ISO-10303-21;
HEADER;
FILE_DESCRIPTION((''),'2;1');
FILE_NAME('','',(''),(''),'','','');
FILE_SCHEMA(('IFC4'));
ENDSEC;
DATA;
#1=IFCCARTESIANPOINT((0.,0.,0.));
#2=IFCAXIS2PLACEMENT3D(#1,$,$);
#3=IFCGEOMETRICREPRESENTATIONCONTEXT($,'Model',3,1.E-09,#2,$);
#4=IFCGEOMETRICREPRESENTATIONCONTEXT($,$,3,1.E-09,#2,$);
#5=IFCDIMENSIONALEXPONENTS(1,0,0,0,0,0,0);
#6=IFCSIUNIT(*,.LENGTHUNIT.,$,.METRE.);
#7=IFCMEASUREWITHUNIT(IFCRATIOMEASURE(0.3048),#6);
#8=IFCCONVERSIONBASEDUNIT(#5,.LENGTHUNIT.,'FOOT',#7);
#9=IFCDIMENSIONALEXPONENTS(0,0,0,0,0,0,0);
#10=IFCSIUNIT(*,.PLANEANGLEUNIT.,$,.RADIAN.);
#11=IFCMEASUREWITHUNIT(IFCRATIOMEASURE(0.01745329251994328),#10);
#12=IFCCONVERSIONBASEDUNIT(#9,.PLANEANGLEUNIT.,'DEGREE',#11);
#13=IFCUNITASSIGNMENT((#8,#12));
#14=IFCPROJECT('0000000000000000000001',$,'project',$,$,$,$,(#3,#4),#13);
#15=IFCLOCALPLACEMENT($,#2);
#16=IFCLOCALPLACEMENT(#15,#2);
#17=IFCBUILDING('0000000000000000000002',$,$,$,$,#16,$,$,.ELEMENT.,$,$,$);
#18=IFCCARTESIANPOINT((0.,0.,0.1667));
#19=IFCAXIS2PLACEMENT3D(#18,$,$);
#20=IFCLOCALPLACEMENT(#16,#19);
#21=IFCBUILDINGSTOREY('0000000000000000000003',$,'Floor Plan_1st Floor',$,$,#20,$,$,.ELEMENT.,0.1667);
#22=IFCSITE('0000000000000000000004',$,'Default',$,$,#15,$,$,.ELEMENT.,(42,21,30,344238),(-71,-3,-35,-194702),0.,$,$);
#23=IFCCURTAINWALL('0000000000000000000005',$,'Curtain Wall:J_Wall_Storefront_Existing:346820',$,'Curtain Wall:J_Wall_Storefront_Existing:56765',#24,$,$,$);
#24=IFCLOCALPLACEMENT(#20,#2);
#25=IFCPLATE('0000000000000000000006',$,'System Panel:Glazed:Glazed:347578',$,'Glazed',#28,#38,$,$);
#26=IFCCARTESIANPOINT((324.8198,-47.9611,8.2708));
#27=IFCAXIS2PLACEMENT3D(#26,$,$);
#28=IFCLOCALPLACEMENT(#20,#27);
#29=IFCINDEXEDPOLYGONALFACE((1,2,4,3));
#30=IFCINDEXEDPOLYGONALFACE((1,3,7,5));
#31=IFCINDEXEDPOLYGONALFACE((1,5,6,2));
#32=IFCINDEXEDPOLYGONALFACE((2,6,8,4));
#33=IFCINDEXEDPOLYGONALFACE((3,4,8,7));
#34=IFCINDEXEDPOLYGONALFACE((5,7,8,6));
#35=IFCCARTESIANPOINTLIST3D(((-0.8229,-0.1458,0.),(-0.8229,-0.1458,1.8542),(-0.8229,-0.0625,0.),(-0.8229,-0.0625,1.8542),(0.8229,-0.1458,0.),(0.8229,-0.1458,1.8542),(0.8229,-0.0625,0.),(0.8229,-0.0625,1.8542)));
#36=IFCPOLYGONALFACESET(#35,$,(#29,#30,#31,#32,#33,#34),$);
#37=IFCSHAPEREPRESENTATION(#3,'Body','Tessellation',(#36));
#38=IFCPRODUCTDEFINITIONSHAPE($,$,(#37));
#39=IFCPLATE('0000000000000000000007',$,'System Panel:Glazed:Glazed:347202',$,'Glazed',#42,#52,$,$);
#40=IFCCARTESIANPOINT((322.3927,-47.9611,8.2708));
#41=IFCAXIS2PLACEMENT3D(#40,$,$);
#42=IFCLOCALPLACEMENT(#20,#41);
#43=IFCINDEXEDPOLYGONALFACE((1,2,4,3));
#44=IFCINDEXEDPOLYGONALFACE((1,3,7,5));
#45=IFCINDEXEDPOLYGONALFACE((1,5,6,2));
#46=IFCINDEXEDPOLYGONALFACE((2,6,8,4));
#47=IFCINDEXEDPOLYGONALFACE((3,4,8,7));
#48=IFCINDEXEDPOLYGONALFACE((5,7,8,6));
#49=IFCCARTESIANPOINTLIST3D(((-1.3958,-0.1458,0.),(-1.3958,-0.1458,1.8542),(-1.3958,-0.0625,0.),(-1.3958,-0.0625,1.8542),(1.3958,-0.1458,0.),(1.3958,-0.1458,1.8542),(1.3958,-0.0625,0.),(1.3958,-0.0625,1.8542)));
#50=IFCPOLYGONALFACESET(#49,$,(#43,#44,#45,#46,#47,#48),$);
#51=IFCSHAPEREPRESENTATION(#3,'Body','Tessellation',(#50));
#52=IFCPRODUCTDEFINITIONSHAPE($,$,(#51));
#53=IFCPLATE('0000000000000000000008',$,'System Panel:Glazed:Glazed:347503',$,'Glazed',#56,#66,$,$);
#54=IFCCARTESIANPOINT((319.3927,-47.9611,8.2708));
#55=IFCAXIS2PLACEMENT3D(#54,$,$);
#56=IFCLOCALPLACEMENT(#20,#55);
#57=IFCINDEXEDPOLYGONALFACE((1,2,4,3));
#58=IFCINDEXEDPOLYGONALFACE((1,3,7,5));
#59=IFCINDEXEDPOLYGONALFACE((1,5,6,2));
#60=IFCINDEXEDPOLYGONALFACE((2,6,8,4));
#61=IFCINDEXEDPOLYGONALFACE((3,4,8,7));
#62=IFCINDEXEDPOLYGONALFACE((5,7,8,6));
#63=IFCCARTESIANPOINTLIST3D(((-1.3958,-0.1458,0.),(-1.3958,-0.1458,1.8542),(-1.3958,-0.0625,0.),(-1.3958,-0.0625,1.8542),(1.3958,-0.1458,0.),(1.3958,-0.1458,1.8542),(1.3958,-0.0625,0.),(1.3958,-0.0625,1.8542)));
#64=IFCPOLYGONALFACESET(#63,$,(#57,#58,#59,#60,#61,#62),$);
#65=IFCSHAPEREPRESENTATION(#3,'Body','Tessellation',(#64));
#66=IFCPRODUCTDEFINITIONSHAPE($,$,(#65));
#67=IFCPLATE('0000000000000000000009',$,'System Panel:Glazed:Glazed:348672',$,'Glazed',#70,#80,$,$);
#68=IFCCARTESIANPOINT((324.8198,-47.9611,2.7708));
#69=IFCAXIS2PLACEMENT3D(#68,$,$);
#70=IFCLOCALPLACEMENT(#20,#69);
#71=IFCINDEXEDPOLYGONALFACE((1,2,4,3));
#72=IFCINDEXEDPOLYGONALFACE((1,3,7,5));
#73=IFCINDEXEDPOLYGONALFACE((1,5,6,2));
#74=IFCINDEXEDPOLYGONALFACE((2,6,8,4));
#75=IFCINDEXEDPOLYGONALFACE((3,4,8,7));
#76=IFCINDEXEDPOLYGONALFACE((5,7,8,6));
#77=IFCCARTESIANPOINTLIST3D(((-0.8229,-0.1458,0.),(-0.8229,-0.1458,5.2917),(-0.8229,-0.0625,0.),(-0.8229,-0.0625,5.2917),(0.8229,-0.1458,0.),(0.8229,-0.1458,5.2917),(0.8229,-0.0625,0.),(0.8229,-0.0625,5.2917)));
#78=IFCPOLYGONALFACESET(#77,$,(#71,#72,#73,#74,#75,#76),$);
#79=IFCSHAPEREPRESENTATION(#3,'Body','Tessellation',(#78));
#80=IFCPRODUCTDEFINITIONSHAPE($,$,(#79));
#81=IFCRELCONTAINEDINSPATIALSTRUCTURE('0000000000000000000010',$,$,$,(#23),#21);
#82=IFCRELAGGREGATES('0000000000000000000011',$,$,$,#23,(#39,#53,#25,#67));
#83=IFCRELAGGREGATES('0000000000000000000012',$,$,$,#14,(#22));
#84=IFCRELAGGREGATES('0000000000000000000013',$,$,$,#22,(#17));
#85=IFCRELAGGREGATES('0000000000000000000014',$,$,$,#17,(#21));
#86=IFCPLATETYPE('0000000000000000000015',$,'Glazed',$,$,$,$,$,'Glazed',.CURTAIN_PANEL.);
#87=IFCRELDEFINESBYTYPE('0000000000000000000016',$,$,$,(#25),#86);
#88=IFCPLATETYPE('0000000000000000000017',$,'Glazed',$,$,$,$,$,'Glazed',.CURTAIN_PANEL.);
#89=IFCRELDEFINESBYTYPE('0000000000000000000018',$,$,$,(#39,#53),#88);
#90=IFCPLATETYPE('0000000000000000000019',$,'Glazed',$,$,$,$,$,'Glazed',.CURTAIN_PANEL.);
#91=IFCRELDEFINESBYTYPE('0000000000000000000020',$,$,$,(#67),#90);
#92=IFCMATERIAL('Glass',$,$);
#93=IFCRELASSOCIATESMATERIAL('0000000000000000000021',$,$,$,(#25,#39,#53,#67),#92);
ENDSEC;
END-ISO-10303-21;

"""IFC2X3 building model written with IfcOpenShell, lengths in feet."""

from ifc_helpers import new_model, entity, si_unit, converted_unit, frame, origin, origin_2d_with_axis, place, context, project, spatial, rectangle, extrude, source, transform, mapped, material, type_object, type_shapes, element, aggregate, save


model = new_model("IFC2X3")

# Units and contexts
model_context = context("Model", 3, precision=1e-09, world=origin())
context_of_model = context(None, 3, precision=1e-09, world=origin())
ifc_project = project(units=[converted_unit("LENGTHUNIT", "FOOT", entity("IfcRatioMeasure", 0.3048), si_unit("LENGTHUNIT", "METRE"), dimensions=[1, 0, 0, 0, 0, 0, 0]), converted_unit("PLANEANGLEUNIT", "DEGREE", entity("IfcRatioMeasure", 0.01745329251994328), si_unit("PLANEANGLEUNIT", "RADIAN"), dimensions=[0, 0, 0, 0, 0, 0, 0])], contexts=[model_context, context_of_model])

# Site, building, storey
site_placement = place(None, origin())
site = spatial("IfcSite", under=ifc_project, at=site_placement, Name="Default", CompositionType="ELEMENT", RefLatitude=(42, 21, 30, 344238), RefLongitude=(-71, -3, -35, -194702), RefElevation=0.0)
building_placement = place(site_placement, origin())
building = spatial("IfcBuilding", under=site, at=building_placement, CompositionType="ELEMENT")
storey_placement = place(building_placement, frame((0.0, 0.0, 0.1667)))
storey = spatial("IfcBuildingStorey", under=building, at=storey_placement, Name="Floor Plan_1st Floor", CompositionType="ELEMENT", Elevation=0.1667)

# Curtain wall, plates
curtain_wall_placement = place(storey_placement, origin())
curtain_wall = element("IfcCurtainWall", 1, at=curtain_wall_placement, inside=storey, Name="Curtain Wall:J_Wall_Storefront_Existing:346820", ObjectType="Curtain Wall:J_Wall_Storefront_Existing:56765")
ifc_material_1 = material(Name="Glass")
plate_type_1 = type_object("IfcPlateType", Name="Glazed", ElementType="Glazed", PredefinedType="CURTAIN_PANEL")
shared_shape_1 = source(origin(), model_context, "Body", "SweptSolid", [
    extrude(rectangle(XDim=0.0833, YDim=1.6458, at=origin_2d_with_axis()), frame((0.0, -0.1042, 0.0), z_axis=(0.0, 0.0, 1.0), x_axis=(0.0, 1.0, 0.0)), (0.0, 0.0, 1.0), 1.8542),
])
type_shapes(plate_type_1, [shared_shape_1])
plate_1_placement = place(storey_placement, frame((324.8198, -47.9611, 8.2708)))
plate_1 = element("IfcPlate", 2, at=plate_1_placement, type_object=plate_type_1, material=ifc_material_1, Name="System Panel:Glazed:Glazed:347578", ObjectType="Glazed", context=model_context, shape_type="MappedRepresentation", body=[
    mapped(shared_shape_1, transform((0.0, 0.0, 0.0), scale=1.0)),
])
plate_type_2 = type_object("IfcPlateType", Name="Glazed", ElementType="Glazed", PredefinedType="CURTAIN_PANEL")
shared_shape_2 = source(origin(), model_context, "Body", "SweptSolid", [
    extrude(rectangle(XDim=0.0833, YDim=2.7917, at=origin_2d_with_axis()), frame((0.0, -0.1042, 0.0), z_axis=(0.0, 0.0, 1.0), x_axis=(0.0, 1.0, 0.0)), (0.0, 0.0, 1.0), 1.8542),
])
type_shapes(plate_type_2, [shared_shape_2])
plate_2_placement = place(storey_placement, frame((322.3927, -47.9611, 8.2708)))
plate_2 = element("IfcPlate", 3, at=plate_2_placement, type_object=plate_type_2, material=ifc_material_1, Name="System Panel:Glazed:Glazed:347202", ObjectType="Glazed", context=model_context, shape_type="MappedRepresentation", body=[
    mapped(shared_shape_2, transform((0.0, 0.0, 0.0), scale=1.0)),
])
plate_3_placement = place(storey_placement, frame((319.3927, -47.9611, 8.2708)))
plate_3 = element("IfcPlate", 4, at=plate_3_placement, type_object=plate_type_2, material=ifc_material_1, Name="System Panel:Glazed:Glazed:347503", ObjectType="Glazed", context=model_context, shape_type="MappedRepresentation", body=[
    mapped(shared_shape_2, transform((0.0, 0.0, 0.0), scale=1.0)),
])
plate_type_3 = type_object("IfcPlateType", Name="Glazed", ElementType="Glazed", PredefinedType="CURTAIN_PANEL")
shared_shape_3 = source(origin(), model_context, "Body", "SweptSolid", [
    extrude(rectangle(XDim=0.0833, YDim=1.6458, at=origin_2d_with_axis()), frame((0.0, -0.1042, 0.0), z_axis=(0.0, 0.0, 1.0), x_axis=(0.0, 1.0, 0.0)), (0.0, 0.0, 1.0), 5.2917),
])
type_shapes(plate_type_3, [shared_shape_3])
plate_4_placement = place(storey_placement, frame((324.8198, -47.9611, 2.7708)))
plate_4 = element("IfcPlate", 5, at=plate_4_placement, type_object=plate_type_3, material=ifc_material_1, Name="System Panel:Glazed:Glazed:348672", ObjectType="Glazed", context=model_context, shape_type="MappedRepresentation", body=[
    mapped(shared_shape_3, transform((0.0, 0.0, 0.0), scale=1.0)),
])
aggregate(curtain_wall, [plate_2, plate_3, plate_1, plate_4])

save(model, "model.ifc")
